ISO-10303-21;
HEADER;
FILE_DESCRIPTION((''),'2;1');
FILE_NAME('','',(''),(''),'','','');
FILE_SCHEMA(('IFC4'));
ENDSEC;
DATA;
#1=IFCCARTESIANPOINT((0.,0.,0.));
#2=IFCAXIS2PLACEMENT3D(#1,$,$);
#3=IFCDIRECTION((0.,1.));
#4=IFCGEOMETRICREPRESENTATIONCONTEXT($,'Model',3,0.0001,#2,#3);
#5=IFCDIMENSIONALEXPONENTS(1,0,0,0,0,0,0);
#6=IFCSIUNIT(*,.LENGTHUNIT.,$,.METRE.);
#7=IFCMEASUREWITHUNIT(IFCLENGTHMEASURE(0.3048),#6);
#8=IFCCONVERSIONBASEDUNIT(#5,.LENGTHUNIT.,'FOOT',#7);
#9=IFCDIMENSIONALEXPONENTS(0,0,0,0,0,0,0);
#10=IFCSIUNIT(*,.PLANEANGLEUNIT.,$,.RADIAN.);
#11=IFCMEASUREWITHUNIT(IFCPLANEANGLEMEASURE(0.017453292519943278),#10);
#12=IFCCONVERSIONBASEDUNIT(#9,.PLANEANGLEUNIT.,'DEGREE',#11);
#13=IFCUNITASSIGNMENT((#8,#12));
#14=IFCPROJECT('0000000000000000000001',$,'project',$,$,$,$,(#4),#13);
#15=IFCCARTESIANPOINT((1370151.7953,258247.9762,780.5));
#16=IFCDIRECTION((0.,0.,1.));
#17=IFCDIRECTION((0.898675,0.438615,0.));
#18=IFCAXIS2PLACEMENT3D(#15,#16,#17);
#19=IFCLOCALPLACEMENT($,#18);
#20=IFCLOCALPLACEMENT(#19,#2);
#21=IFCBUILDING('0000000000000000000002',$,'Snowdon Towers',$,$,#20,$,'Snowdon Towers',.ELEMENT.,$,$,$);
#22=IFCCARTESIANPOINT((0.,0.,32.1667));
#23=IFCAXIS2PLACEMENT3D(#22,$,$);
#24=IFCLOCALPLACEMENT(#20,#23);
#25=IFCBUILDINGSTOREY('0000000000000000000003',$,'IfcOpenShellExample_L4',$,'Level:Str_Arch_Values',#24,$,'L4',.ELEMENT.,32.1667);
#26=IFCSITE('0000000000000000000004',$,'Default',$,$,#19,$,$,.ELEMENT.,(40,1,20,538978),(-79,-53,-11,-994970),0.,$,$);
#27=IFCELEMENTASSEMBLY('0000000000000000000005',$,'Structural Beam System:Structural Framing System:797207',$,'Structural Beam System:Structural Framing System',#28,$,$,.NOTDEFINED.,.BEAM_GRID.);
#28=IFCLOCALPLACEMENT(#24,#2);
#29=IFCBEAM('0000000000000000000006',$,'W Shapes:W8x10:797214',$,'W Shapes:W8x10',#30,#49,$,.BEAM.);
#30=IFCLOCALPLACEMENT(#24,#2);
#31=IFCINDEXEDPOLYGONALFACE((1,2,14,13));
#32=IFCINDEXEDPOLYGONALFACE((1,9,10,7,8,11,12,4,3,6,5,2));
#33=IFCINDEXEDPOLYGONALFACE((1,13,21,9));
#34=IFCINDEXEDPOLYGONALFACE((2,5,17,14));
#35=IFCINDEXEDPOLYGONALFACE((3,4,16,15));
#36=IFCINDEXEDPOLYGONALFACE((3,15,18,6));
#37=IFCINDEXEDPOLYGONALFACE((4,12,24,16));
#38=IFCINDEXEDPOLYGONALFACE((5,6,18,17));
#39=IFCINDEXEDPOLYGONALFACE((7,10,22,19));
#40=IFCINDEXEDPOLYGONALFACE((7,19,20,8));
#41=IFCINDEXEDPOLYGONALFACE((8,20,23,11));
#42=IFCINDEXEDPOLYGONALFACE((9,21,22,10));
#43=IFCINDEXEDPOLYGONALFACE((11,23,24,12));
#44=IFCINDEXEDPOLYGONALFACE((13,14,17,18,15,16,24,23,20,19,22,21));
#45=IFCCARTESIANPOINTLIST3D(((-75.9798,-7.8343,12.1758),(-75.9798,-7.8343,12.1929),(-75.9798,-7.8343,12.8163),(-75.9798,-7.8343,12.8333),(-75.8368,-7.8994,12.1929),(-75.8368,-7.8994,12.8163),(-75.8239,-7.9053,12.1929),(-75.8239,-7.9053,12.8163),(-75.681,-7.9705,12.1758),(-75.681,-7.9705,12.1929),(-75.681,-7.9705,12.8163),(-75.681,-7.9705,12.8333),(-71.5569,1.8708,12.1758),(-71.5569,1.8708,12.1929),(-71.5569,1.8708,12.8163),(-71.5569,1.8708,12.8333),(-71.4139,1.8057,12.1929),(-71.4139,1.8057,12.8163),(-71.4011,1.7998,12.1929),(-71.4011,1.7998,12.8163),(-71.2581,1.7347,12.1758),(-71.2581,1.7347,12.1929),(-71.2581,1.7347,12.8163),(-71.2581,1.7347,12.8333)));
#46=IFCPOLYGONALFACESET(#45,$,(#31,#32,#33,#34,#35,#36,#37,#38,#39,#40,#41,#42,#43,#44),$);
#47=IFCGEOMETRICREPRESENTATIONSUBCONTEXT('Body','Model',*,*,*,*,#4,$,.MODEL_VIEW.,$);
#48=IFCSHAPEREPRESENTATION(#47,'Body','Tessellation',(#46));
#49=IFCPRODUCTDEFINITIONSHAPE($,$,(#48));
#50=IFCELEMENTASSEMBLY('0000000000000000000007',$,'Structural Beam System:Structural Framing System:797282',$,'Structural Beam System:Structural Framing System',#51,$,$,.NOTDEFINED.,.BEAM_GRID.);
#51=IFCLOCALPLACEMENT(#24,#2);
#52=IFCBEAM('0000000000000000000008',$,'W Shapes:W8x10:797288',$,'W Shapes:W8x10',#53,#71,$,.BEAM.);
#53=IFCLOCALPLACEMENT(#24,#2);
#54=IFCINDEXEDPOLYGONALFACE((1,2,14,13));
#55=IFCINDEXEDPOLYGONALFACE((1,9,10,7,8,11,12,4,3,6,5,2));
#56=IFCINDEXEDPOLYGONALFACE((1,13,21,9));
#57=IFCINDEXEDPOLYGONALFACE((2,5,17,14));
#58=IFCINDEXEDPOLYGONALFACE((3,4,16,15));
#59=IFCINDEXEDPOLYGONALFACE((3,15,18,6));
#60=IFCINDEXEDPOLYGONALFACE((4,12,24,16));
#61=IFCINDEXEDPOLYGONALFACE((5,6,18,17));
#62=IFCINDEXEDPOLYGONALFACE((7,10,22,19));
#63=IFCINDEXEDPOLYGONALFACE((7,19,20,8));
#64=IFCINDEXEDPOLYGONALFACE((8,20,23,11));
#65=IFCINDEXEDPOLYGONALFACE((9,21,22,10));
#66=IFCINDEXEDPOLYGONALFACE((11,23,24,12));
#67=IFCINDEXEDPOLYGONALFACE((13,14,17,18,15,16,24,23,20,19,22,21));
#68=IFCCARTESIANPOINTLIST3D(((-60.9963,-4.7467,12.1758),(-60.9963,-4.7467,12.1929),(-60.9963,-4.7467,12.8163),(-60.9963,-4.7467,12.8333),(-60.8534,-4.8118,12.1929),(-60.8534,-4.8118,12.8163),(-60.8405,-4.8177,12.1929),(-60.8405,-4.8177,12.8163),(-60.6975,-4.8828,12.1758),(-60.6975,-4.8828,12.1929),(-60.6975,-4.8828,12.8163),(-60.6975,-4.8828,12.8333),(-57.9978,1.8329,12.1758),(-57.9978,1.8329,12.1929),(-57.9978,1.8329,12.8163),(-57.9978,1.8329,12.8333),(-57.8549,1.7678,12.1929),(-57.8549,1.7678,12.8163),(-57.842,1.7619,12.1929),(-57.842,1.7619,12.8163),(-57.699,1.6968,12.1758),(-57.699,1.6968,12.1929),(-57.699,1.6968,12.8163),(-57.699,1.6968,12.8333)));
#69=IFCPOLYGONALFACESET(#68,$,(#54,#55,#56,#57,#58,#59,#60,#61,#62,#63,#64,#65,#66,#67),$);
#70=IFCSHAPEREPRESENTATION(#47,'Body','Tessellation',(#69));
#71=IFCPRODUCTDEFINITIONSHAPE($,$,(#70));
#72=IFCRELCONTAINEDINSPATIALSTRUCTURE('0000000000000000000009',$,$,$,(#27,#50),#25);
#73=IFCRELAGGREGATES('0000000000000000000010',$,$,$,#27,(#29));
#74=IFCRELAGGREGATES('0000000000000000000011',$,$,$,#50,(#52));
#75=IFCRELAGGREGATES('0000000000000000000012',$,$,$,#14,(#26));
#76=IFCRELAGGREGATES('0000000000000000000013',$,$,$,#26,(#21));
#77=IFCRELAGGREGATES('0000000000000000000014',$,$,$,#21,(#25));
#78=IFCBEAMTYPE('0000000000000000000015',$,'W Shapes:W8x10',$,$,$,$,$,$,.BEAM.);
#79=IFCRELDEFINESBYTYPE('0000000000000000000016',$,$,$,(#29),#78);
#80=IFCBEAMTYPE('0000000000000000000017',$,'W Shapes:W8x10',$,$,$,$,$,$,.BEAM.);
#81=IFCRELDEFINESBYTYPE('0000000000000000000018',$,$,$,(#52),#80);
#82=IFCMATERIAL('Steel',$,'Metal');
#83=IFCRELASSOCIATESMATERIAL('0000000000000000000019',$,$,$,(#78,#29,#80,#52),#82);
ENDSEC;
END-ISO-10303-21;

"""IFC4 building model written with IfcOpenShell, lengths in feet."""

from ifc_helpers import new_model, entity, si_unit, converted_unit, direction, frame, origin, place, context, subcontext, project, spatial, indexed_curve, outline, extrude, source, transform, mapped, material, type_object, type_shapes, element, aggregate, save


model = new_model("IFC4")

# Units and contexts
model_context = context("Model", 3, precision=0.0001, world=origin(), true_north=direction((0.0, 1.0)))
body_context = subcontext(model_context, "Body", "Model", "MODEL_VIEW")
ifc_project = project(units=[converted_unit("LENGTHUNIT", "FOOT", entity("IfcLengthMeasure", 0.3048), si_unit("LENGTHUNIT", "METRE"), dimensions=[1, 0, 0, 0, 0, 0, 0]), converted_unit("PLANEANGLEUNIT", "DEGREE", entity("IfcPlaneAngleMeasure", 0.017453292519943278), si_unit("PLANEANGLEUNIT", "RADIAN"), dimensions=[0, 0, 0, 0, 0, 0, 0])], contexts=[model_context])

# Site, building, storey
site_placement = place(None, frame((1370151.7953, 258247.9762, 780.5), z_axis=(0.0, 0.0, 1.0), x_axis=(0.898675, 0.438615, 0.0)))
site = spatial("IfcSite", under=ifc_project, at=site_placement, Name="Default", CompositionType="ELEMENT", RefLatitude=(40, 1, 20, 538978), RefLongitude=(-79, -53, -11, -994970), RefElevation=0.0)
building_placement = place(site_placement, origin())
building = spatial("IfcBuilding", under=site, at=building_placement, Name="Snowdon Towers", LongName="Snowdon Towers", CompositionType="ELEMENT")
storey_placement = place(building_placement, frame((0.0, 0.0, 32.1667)))
storey = spatial("IfcBuildingStorey", under=building, at=storey_placement, Name="IfcOpenShellExample_L4", ObjectType="Level:Str_Arch_Values", LongName="L4", CompositionType="ELEMENT", Elevation=32.1667)

# Shared definitions
ifc_material = material(Name="Steel", Category="Metal")

# Element assembly
assembly_1_placement = place(storey_placement, origin())
assembly_1 = element("IfcElementAssembly", 1, at=assembly_1_placement, inside=storey, Name="Structural Beam System:Structural Framing System:797207", ObjectType="Structural Beam System:Structural Framing System", AssemblyPlace="NOTDEFINED", PredefinedType="BEAM_GRID")

# Beam
beam_type_1 = type_object("IfcBeamType", Name="W Shapes:W8x10", PredefinedType="BEAM", material=ifc_material)
shared_shape_1 = source(origin(), body_context, "Body", "SweptSolid", [
    extrude(outline(indexed_curve([(-0.1642, -0.3117), (-0.1642, -0.3288), (0.1642, -0.3288), (0.1642, -0.3117), (0.0071, -0.3117), (0.0071, 0.3117), (0.1642, 0.3117), (0.1642, 0.3287), (-0.1642, 0.3287), (-0.1642, 0.3117), (-0.0071, 0.3117), (-0.0071, -0.3117), (-0.1642, -0.3117)], self_intersect=False)), frame((-5.5806, 0.0, 0.0), z_axis=(-1.0, 0.0, 0.0), x_axis=(0.0, -1.0, 0.0)), (0.0, 0.0, -1.0), 10.6654),
])
type_shapes(beam_type_1, [shared_shape_1])
beam_1_placement = place(assembly_1_placement, frame((-73.5161, -2.8242, 12.5046), z_axis=(0.0, 0.0, 1.0), x_axis=(0.414693, 0.909961, 0.0)))
beam_1 = element("IfcBeam", 2, at=beam_1_placement, type_object=beam_type_1, material=ifc_material, Name="W Shapes:W8x10:797214", ObjectType="W Shapes:W8x10", PredefinedType="BEAM", context=body_context, shape_type="MappedRepresentation", body=[
    mapped(shared_shape_1, transform((0.0, 0.0, 0.0), scale=1.0)),
])
aggregate(assembly_1, [beam_1])

# Element assembly, beam
assembly_2_placement = place(storey_placement, origin())
assembly_2 = element("IfcElementAssembly", 3, at=assembly_2_placement, inside=storey, Name="Structural Beam System:Structural Framing System:797282", ObjectType="Structural Beam System:Structural Framing System", AssemblyPlace="NOTDEFINED", PredefinedType="BEAM_GRID")
beam_type_2 = type_object("IfcBeamType", Name="W Shapes:W8x10", PredefinedType="BEAM", material=ifc_material)
shared_shape_2 = source(origin(), body_context, "Body", "SweptSolid", [
    extrude(outline(indexed_curve([(-0.1642, -0.3117), (-0.1642, -0.3288), (0.1642, -0.3288), (0.1642, -0.3117), (0.0071, -0.3117), (0.0071, 0.3117), (0.1642, 0.3117), (0.1642, 0.3287), (-0.1642, 0.3287), (-0.1642, 0.3117), (-0.0071, 0.3117), (-0.0071, -0.3117), (-0.1642, -0.3117)], self_intersect=False)), frame((-3.8632, 0.0, 0.0), z_axis=(-1.0, 0.0, 0.0), x_axis=(0.0, -1.0, 0.0)), (0.0, 0.0, -1.0), 7.2306),
])
type_shapes(beam_type_2, [shared_shape_2])
beam_2_placement = place(assembly_2_placement, frame((-59.2449, -1.2994, 12.5046), z_axis=(0.0, 0.0, 1.0), x_axis=(0.414693, 0.909961, 0.0)))
beam_2 = element("IfcBeam", 4, at=beam_2_placement, type_object=beam_type_2, material=ifc_material, Name="W Shapes:W8x10:797288", ObjectType="W Shapes:W8x10", PredefinedType="BEAM", context=body_context, shape_type="MappedRepresentation", body=[
    mapped(shared_shape_2, transform((0.0, 0.0, 0.0), scale=1.0)),
])
aggregate(assembly_2, [beam_2])

save(model, "model.ifc")
